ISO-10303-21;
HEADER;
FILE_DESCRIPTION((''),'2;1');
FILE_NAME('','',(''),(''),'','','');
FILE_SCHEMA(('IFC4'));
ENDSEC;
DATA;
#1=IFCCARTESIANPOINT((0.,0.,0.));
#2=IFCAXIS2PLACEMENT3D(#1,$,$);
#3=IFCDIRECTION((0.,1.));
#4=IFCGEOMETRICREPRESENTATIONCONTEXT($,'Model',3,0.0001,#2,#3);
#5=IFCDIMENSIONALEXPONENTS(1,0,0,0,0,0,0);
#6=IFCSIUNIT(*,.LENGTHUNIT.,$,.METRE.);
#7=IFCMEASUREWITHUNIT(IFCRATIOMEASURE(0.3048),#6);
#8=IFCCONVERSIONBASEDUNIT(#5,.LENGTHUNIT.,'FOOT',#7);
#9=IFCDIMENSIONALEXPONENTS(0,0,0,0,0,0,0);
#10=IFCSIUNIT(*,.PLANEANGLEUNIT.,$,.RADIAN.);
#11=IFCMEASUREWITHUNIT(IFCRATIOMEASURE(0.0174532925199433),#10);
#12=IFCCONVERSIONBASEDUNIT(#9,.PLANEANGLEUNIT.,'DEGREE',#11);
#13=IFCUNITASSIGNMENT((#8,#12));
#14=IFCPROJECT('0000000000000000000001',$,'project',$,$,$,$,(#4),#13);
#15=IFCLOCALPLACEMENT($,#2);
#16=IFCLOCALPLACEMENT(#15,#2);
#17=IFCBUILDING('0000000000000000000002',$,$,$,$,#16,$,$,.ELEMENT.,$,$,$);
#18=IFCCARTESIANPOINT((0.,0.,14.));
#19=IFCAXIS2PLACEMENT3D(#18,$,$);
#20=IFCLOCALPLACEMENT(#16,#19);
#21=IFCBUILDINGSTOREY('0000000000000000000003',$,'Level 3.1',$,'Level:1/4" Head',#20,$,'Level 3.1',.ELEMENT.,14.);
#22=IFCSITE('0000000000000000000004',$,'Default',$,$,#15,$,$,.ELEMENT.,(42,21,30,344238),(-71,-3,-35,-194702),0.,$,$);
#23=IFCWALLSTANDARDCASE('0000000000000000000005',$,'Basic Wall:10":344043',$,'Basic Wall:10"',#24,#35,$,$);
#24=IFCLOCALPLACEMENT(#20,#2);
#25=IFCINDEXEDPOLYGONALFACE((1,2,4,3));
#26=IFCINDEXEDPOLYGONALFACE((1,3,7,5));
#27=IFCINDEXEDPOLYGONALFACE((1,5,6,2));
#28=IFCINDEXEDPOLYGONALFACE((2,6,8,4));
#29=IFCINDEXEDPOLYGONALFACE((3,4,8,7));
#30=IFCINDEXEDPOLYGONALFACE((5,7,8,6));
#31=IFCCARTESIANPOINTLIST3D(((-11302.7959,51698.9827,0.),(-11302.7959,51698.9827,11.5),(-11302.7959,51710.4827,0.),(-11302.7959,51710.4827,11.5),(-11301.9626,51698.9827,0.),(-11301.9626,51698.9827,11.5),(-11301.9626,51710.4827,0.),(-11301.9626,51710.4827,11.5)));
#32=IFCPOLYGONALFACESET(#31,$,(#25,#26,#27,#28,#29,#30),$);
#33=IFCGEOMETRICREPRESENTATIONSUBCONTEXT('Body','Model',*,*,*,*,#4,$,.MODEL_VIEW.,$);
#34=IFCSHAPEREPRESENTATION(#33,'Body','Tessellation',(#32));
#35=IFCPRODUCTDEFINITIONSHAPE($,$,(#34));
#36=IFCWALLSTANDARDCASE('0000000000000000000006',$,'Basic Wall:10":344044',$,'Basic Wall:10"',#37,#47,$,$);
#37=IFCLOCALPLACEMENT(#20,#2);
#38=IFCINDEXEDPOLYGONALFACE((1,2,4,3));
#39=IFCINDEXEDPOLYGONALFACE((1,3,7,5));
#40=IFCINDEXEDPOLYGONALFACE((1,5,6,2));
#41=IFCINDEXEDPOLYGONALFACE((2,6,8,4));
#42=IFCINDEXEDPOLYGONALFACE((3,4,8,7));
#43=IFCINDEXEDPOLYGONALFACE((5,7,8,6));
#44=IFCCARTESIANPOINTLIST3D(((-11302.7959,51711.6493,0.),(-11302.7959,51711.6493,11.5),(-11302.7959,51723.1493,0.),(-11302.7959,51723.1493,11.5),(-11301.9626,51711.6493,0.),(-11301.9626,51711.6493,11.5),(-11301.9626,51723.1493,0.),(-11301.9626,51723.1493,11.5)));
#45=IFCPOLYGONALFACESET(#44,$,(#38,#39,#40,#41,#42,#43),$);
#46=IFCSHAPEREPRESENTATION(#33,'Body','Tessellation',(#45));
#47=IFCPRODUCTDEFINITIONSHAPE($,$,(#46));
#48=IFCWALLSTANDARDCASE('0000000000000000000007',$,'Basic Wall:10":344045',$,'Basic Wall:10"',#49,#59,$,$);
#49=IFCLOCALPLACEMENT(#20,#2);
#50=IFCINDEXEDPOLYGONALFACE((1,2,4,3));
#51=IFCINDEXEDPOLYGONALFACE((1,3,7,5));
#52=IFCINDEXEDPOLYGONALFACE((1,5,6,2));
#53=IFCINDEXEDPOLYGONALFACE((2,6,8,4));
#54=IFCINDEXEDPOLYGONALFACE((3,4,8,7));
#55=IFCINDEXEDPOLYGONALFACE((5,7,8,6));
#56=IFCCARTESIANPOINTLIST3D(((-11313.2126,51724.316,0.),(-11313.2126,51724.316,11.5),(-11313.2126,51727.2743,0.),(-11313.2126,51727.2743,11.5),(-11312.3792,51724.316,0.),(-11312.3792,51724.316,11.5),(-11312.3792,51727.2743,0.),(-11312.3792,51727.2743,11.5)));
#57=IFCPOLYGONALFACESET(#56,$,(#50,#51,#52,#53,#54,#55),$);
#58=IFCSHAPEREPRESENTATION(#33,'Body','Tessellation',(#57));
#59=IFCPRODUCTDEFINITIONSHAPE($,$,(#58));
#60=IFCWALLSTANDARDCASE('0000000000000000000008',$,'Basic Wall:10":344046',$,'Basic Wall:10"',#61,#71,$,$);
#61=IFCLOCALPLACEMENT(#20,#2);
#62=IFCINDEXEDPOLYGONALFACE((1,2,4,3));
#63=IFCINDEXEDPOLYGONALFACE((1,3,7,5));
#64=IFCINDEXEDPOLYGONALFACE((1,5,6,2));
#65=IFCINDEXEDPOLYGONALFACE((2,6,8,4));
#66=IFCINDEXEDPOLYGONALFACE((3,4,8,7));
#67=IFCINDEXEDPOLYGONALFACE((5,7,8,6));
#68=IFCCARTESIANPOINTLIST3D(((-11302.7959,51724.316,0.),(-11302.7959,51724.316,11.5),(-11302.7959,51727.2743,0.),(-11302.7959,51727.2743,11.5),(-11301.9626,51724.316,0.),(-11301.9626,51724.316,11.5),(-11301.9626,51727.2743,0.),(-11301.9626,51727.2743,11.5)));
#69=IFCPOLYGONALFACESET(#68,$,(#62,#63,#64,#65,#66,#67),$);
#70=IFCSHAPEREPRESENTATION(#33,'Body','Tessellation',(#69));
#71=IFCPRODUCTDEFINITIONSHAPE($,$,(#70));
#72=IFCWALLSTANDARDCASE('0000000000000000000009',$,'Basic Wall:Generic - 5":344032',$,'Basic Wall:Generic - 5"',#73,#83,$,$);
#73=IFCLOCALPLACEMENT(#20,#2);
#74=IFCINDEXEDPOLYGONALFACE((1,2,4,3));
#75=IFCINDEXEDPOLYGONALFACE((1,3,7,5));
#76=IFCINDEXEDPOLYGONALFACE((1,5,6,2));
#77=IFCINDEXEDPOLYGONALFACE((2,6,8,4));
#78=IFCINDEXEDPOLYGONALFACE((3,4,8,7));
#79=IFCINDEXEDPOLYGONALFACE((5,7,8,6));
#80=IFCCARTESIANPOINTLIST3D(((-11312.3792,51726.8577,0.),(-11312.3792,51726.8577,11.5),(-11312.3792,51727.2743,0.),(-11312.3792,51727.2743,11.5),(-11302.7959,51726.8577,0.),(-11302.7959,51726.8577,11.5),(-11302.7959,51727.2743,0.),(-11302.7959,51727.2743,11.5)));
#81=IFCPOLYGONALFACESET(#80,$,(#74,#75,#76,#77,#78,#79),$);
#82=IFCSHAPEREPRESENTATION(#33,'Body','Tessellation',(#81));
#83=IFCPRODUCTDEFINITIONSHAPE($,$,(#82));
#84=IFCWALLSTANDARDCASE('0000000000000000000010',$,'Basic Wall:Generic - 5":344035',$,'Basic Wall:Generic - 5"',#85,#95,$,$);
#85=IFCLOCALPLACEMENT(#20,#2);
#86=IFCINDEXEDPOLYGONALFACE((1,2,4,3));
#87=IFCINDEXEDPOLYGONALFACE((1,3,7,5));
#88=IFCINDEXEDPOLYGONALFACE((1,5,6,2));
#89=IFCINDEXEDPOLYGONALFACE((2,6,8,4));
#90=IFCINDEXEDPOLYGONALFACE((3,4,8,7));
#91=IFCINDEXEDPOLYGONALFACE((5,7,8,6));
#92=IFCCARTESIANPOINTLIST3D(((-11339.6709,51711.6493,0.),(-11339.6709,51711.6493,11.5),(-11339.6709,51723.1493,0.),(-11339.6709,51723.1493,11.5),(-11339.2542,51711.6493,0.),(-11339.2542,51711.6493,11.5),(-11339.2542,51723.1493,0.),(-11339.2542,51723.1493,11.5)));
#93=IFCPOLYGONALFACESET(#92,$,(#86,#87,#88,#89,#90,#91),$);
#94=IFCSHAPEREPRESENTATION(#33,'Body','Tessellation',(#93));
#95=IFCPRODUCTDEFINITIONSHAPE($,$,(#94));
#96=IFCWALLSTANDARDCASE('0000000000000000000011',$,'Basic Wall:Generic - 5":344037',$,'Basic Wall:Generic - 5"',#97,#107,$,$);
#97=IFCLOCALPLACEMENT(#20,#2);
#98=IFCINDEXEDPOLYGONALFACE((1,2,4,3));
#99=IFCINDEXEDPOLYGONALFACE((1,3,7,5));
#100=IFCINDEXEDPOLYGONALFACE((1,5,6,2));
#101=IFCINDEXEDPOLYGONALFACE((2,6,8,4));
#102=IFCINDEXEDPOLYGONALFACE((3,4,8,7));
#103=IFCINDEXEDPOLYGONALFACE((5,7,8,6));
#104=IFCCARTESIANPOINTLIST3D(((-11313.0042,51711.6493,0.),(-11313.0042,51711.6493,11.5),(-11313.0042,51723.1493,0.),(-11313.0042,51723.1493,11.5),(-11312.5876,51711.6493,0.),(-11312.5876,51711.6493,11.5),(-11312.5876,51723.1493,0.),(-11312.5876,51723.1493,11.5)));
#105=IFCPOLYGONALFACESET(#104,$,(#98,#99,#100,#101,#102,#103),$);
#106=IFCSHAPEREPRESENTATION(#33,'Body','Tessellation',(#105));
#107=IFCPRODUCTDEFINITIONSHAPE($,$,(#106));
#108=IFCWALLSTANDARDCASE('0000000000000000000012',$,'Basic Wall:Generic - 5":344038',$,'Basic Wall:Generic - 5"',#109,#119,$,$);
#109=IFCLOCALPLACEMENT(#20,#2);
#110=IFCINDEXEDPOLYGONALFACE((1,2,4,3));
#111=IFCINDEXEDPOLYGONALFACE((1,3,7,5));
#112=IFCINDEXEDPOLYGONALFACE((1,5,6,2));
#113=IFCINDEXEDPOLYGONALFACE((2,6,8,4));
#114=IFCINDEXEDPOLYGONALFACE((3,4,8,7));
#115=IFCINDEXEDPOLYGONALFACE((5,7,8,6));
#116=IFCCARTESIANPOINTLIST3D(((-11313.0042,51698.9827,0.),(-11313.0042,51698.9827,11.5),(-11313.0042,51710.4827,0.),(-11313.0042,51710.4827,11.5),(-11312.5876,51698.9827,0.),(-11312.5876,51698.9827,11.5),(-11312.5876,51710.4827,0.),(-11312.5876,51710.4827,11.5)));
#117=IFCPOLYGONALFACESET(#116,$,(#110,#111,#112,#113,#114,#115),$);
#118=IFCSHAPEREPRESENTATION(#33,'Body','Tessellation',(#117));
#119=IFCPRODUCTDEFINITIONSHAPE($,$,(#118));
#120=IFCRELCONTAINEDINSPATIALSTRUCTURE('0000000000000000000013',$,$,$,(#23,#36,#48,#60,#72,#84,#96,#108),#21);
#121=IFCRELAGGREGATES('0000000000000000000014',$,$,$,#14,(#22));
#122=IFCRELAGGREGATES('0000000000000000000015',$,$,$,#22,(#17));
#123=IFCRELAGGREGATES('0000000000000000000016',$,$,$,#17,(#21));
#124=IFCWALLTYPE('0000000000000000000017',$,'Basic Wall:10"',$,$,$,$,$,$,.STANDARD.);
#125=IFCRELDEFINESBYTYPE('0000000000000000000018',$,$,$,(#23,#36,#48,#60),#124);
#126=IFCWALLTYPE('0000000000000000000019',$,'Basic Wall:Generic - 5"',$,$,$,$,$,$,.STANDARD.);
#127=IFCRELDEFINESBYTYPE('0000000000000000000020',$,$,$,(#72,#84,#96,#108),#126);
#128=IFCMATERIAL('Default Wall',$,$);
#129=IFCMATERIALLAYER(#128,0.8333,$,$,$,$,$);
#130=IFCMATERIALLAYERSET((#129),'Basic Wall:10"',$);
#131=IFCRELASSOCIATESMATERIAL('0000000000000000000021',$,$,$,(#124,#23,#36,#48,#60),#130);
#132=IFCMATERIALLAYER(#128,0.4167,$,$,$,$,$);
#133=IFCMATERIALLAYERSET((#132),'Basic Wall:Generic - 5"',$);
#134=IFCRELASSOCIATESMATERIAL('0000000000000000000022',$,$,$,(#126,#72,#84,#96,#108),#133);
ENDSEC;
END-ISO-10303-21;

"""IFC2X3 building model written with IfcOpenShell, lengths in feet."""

from ifc_helpers import new_model, entity, si_unit, converted_unit, direction, frame, frame_2d, origin, place, context, subcontext, project, spatial, rectangle, extrude, material, layer, layer_set, layer_usage, type_object, element, save


model = new_model("IFC2X3")

# Units and contexts
model_context = context("Model", 3, precision=0.0001, world=origin(), true_north=direction((0.0, 1.0)))
body_context = subcontext(model_context, "Body", "Model", "MODEL_VIEW")
ifc_project = project(units=[converted_unit("LENGTHUNIT", "FOOT", entity("IfcRatioMeasure", 0.3048), si_unit("LENGTHUNIT", "METRE"), dimensions=[1, 0, 0, 0, 0, 0, 0]), converted_unit("PLANEANGLEUNIT", "DEGREE", entity("IfcRatioMeasure", 0.0174532925199433), si_unit("PLANEANGLEUNIT", "RADIAN"), dimensions=[0, 0, 0, 0, 0, 0, 0])], contexts=[model_context])

# Site, building, storey
site_placement = place(None, origin())
site = spatial("IfcSite", under=ifc_project, at=site_placement, Name="Default", CompositionType="ELEMENT", RefLatitude=(42, 21, 30, 344238), RefLongitude=(-71, -3, -35, -194702), RefElevation=0.0)
building_placement = place(site_placement, origin())
building = spatial("IfcBuilding", under=site, at=building_placement, CompositionType="ELEMENT")
storey_placement = place(building_placement, frame((0.0, 0.0, 14.0)))
storey = spatial("IfcBuildingStorey", under=building, at=storey_placement, Name="Level 3.1", ObjectType="Level:1/4\" Head", LongName="Level 3.1", CompositionType="ELEMENT", Elevation=14.0)

# Walls
ifc_material_1 = material(Name="Default Wall")
ifc_layer_1 = layer(ifc_material_1, 0.8333)
ifc_layer_set_1 = layer_set([ifc_layer_1], Name="Basic Wall:10\"")
ifc_layer_usage_1 = layer_usage(ifc_layer_set_1, "AXIS2", "NEGATIVE", 0.4167)
wall_type_1 = type_object("IfcWallType", Name="Basic Wall:10\"", PredefinedType="STANDARD", material=ifc_layer_set_1)
wall_1_placement = place(storey_placement, frame((-11302.3792, 51698.9827, 0.0), z_axis=(0.0, 0.0, 1.0), x_axis=(0.0, 1.0, 0.0)))
element("IfcWallStandardCase", 1, at=wall_1_placement, inside=storey, type_object=wall_type_1, material=ifc_layer_usage_1, Name="Basic Wall:10\":344043", ObjectType="Basic Wall:10\"", context=body_context, shape_type="SweptSolid", body=[
    extrude(rectangle(XDim=11.5, YDim=0.8333, at=frame_2d((5.75, 0.0), x_axis=(-1.0, 0.0))), origin(), (0.0, 0.0, 1.0), 11.5),
])
ifc_layer_usage_2 = layer_usage(ifc_layer_set_1, "AXIS2", "NEGATIVE", 0.4167)
wall_2_placement = place(storey_placement, frame((-11302.3792, 51711.6493, 0.0), z_axis=(0.0, 0.0, 1.0), x_axis=(0.0, 1.0, 0.0)))
element("IfcWallStandardCase", 2, at=wall_2_placement, inside=storey, type_object=wall_type_1, material=ifc_layer_usage_2, Name="Basic Wall:10\":344044", ObjectType="Basic Wall:10\"", context=body_context, shape_type="SweptSolid", body=[
    extrude(rectangle(XDim=11.5, YDim=0.8333, at=frame_2d((5.75, 0.0), x_axis=(-1.0, 0.0))), origin(), (0.0, 0.0, 1.0), 11.5),
])
ifc_layer_usage_3 = layer_usage(ifc_layer_set_1, "AXIS2", "NEGATIVE", 0.4167)
wall_3_placement = place(storey_placement, frame((-11312.7959, 51724.316, 0.0), z_axis=(0.0, 0.0, 1.0), x_axis=(0.0, 1.0, 0.0)))
element("IfcWallStandardCase", 3, at=wall_3_placement, inside=storey, type_object=wall_type_1, material=ifc_layer_usage_3, Name="Basic Wall:10\":344045", ObjectType="Basic Wall:10\"", context=body_context, shape_type="SweptSolid", body=[
    extrude(rectangle(XDim=2.9583, YDim=0.8333, at=frame_2d((1.4792, 0.0), x_axis=(-1.0, 0.0))), origin(), (0.0, 0.0, 1.0), 11.5),
])
ifc_layer_usage_4 = layer_usage(ifc_layer_set_1, "AXIS2", "NEGATIVE", 0.4167)
wall_4_placement = place(storey_placement, frame((-11302.3792, 51724.316, 0.0), z_axis=(0.0, 0.0, 1.0), x_axis=(0.0, 1.0, 0.0)))
element("IfcWallStandardCase", 4, at=wall_4_placement, inside=storey, type_object=wall_type_1, material=ifc_layer_usage_4, Name="Basic Wall:10\":344046", ObjectType="Basic Wall:10\"", context=body_context, shape_type="SweptSolid", body=[
    extrude(rectangle(XDim=2.9583, YDim=0.8333, at=frame_2d((1.4792, 0.0), x_axis=(-1.0, 0.0))), origin(), (0.0, 0.0, 1.0), 11.5),
])

# Shared definitions
ifc_layer_2 = layer(ifc_material_1, 0.4167)
ifc_layer_set_2 = layer_set([ifc_layer_2], Name="Basic Wall:Generic - 5\"")
wall_type_2 = type_object("IfcWallType", Name="Basic Wall:Generic - 5\"", PredefinedType="STANDARD", material=ifc_layer_set_2)

# Walls
ifc_layer_usage_5 = layer_usage(ifc_layer_set_2, "AXIS2", "NEGATIVE", 0.2083)
wall_5_placement = place(storey_placement, frame((-11312.3792, 51727.066, 0.0)))
element("IfcWallStandardCase", 5, at=wall_5_placement, inside=storey, type_object=wall_type_2, material=ifc_layer_usage_5, Name="Basic Wall:Generic - 5\":344032", ObjectType="Basic Wall:Generic - 5\"", context=body_context, shape_type="SweptSolid", body=[
    extrude(rectangle(XDim=9.5833, YDim=0.4167, at=frame_2d((4.7917, 0.0), x_axis=(-1.0, 0.0))), origin(), (0.0, 0.0, 1.0), 11.5),
])
ifc_layer_usage_6 = layer_usage(ifc_layer_set_2, "AXIS2", "NEGATIVE", 0.2083)
wall_6_placement = place(storey_placement, frame((-11339.4626, 51723.1493, 0.0), z_axis=(0.0, 0.0, 1.0), x_axis=(0.0, -1.0, 0.0)))
element("IfcWallStandardCase", 6, at=wall_6_placement, inside=storey, type_object=wall_type_2, material=ifc_layer_usage_6, Name="Basic Wall:Generic - 5\":344035", ObjectType="Basic Wall:Generic - 5\"", context=body_context, shape_type="SweptSolid", body=[
    extrude(rectangle(XDim=11.5, YDim=0.4167, at=frame_2d((5.75, 0.0), x_axis=(-1.0, 0.0))), origin(), (0.0, 0.0, 1.0), 11.5),
])
ifc_layer_usage_7 = layer_usage(ifc_layer_set_2, "AXIS2", "NEGATIVE", 0.2083)
wall_7_placement = place(storey_placement, frame((-11312.7959, 51723.1493, 0.0), z_axis=(0.0, 0.0, 1.0), x_axis=(0.0, -1.0, 0.0)))
element("IfcWallStandardCase", 7, at=wall_7_placement, inside=storey, type_object=wall_type_2, material=ifc_layer_usage_7, Name="Basic Wall:Generic - 5\":344037", ObjectType="Basic Wall:Generic - 5\"", context=body_context, shape_type="SweptSolid", body=[
    extrude(rectangle(XDim=11.5, YDim=0.4167, at=frame_2d((5.75, 0.0), x_axis=(-1.0, 0.0))), origin(), (0.0, 0.0, 1.0), 11.5),
])
ifc_layer_usage_8 = layer_usage(ifc_layer_set_2, "AXIS2", "NEGATIVE", 0.2083)
wall_8_placement = place(storey_placement, frame((-11312.7959, 51710.4827, 0.0), z_axis=(0.0, 0.0, 1.0), x_axis=(0.0, -1.0, 0.0)))
element("IfcWallStandardCase", 8, at=wall_8_placement, inside=storey, type_object=wall_type_2, material=ifc_layer_usage_8, Name="Basic Wall:Generic - 5\":344038", ObjectType="Basic Wall:Generic - 5\"", context=body_context, shape_type="SweptSolid", body=[
    extrude(rectangle(XDim=11.5, YDim=0.4167, at=frame_2d((5.75, 0.0), x_axis=(-1.0, 0.0))), origin(), (0.0, 0.0, 1.0), 11.5),
])

save(model, "model.ifc")
